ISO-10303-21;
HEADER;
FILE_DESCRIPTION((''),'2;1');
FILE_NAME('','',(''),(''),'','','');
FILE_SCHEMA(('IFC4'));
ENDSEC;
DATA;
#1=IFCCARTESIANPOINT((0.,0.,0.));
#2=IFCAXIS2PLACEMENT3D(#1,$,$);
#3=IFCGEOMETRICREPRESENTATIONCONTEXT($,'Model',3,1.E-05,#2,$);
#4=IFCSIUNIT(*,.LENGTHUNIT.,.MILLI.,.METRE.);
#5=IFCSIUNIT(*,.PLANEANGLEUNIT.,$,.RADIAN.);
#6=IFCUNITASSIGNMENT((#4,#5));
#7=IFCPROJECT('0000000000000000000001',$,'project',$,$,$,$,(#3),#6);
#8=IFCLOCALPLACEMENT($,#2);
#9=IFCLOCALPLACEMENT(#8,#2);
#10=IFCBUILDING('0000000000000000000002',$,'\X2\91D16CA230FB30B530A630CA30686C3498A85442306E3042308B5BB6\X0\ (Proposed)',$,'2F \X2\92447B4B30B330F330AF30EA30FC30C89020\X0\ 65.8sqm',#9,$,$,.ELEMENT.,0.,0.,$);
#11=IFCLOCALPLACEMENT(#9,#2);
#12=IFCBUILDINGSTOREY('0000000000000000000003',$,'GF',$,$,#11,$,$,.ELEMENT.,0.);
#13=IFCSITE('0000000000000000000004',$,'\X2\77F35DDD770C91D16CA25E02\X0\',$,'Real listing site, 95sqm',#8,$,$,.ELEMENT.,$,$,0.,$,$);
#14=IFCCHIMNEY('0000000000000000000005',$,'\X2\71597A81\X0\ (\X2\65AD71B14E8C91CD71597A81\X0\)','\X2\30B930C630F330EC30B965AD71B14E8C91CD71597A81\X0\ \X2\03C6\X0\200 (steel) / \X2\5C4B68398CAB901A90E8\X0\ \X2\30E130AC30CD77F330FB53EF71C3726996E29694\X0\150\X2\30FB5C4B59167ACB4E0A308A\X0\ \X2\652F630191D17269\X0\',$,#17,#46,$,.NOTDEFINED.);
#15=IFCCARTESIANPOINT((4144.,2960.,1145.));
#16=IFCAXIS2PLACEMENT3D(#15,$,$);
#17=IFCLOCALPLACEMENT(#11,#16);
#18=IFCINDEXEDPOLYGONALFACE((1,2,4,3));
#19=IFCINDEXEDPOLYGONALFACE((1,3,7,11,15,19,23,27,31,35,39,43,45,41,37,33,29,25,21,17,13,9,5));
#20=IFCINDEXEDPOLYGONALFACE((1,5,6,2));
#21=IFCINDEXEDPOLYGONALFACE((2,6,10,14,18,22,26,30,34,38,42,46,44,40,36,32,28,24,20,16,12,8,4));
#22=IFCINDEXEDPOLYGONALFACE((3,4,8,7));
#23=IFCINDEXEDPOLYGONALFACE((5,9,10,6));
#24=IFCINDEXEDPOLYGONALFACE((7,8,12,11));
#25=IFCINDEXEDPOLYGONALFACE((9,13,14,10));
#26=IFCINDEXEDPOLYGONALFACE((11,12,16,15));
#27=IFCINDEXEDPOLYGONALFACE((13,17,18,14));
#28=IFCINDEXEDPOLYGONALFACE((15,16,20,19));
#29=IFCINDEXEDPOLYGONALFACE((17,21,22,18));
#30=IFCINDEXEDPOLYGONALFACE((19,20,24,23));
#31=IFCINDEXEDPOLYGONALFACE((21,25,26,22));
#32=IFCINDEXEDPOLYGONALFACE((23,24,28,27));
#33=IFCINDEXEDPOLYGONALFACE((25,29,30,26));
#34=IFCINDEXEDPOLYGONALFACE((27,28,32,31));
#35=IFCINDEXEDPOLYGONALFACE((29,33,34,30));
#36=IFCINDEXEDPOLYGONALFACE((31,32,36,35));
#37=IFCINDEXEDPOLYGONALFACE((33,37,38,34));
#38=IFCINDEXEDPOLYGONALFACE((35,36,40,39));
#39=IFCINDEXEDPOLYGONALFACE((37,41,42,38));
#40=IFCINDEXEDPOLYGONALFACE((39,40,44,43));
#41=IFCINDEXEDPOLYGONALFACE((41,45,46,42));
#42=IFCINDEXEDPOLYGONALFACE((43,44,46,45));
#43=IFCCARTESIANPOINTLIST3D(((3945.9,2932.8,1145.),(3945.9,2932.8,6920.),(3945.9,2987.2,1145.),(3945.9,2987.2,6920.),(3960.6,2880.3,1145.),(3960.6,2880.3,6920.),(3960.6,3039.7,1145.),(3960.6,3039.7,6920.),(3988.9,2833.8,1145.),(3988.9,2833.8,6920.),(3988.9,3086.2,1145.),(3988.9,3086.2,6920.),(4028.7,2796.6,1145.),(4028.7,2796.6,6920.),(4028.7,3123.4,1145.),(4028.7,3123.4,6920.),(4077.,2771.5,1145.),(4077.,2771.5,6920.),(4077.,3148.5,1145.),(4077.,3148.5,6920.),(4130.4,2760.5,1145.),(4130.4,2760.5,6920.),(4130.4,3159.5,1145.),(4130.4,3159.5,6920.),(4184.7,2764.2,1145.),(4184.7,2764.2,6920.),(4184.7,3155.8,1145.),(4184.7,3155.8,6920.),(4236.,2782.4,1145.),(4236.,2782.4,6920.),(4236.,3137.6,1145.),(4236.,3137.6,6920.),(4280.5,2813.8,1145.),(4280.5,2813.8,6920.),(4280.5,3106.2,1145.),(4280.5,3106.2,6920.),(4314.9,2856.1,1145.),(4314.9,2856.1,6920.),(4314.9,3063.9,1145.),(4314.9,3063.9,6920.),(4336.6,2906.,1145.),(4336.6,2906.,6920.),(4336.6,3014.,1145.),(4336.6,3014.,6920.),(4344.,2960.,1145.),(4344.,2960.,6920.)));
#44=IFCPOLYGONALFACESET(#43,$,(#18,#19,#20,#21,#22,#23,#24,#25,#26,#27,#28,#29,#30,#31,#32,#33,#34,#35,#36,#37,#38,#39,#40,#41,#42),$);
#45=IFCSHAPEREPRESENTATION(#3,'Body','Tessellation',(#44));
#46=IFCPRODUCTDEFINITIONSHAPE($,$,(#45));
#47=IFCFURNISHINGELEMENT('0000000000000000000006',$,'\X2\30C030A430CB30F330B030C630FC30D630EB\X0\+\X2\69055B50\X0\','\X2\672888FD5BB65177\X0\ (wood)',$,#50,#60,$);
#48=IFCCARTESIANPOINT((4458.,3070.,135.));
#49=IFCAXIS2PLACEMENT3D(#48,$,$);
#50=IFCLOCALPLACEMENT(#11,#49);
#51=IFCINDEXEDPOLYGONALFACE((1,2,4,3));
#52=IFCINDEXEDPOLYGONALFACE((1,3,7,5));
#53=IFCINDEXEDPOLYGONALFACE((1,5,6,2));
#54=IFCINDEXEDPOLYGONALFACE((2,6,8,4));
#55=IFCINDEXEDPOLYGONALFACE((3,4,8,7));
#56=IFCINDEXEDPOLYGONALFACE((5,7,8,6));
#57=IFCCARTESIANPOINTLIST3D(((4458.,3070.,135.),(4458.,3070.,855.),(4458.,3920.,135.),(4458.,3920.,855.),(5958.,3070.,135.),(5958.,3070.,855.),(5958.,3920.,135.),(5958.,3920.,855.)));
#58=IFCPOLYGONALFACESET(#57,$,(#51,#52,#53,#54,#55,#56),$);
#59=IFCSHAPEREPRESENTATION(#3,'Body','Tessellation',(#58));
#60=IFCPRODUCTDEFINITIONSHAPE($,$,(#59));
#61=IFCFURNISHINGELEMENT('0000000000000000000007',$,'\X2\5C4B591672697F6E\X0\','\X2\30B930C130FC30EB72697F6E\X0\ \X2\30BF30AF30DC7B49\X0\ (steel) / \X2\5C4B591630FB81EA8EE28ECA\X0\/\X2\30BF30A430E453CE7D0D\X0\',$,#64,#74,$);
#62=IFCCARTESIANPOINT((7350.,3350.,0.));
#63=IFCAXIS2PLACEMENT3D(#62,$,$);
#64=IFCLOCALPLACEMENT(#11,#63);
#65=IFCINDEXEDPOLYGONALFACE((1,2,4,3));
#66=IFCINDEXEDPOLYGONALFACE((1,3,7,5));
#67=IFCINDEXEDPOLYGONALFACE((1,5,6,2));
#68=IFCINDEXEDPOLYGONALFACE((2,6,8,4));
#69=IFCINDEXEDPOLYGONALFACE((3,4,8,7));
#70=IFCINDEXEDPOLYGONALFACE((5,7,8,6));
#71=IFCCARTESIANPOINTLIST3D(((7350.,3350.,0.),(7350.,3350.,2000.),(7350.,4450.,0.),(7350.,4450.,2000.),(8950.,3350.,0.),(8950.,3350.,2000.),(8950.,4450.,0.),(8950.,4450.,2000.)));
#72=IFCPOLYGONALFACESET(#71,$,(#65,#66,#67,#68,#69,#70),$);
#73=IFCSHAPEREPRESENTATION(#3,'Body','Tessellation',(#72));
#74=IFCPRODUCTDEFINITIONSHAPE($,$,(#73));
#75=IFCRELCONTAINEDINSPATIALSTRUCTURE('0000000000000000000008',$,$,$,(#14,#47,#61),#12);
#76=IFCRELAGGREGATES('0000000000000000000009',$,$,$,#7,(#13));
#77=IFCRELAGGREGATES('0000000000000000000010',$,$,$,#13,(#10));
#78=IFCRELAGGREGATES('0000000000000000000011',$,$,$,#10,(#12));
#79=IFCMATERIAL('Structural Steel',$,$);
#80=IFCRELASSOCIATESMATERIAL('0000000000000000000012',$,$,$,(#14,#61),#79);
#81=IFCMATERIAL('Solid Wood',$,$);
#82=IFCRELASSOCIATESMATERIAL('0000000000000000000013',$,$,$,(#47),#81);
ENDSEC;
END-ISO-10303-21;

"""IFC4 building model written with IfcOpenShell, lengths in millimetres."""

from ifc_helpers import new_model, si_unit, frame, frame_2d, origin, origin_2d, place, context, project, spatial, rectangle, circle, extrude, material, element, save


model = new_model("IFC4")

# Units and contexts
model_context = context("Model", 3, precision=1e-05, world=origin())
ifc_project = project(units=[si_unit("LENGTHUNIT", "METRE", prefix="MILLI"), si_unit("PLANEANGLEUNIT", "RADIAN")], contexts=[model_context])

# Site, building, storey
site_placement = place(None, origin())
site = spatial("IfcSite", under=ifc_project, at=site_placement, Name="石川県金沢市", ObjectType="Real listing site, 95sqm", CompositionType="ELEMENT", RefElevation=0.0)
building_placement = place(site_placement, origin())
building = spatial("IfcBuilding", under=site, at=building_placement, Name="金沢・サウナと水風呂のある家 (Proposed)", ObjectType="2F 鉄筋コンクリート造 65.8sqm", CompositionType="ELEMENT", ElevationOfRefHeight=0.0, ElevationOfTerrain=0.0)
storey_placement = place(building_placement, origin())
storey = spatial("IfcBuildingStorey", under=building, at=storey_placement, Name="GF", CompositionType="ELEMENT", Elevation=0.0)

# Shared definitions
ifc_material_1 = material(Name="Solid Wood")

# Shared definitions
ifc_material_2 = material(Name="Structural Steel")

# Chimney
chimney_placement = place(storey_placement, frame((4144.0, 2960.0, 1145.0)))
element("IfcChimney", 1, at=chimney_placement, inside=storey, material=ifc_material_2, Name="煙突 (断熱二重煙突)", Description="ステンレス断熱二重煙突 φ200 (steel) / 屋根貫通部 メガネ石・可燃物離隔150・屋外立上り 支持金物", PredefinedType="NOTDEFINED", context=model_context, shape_type="SweptSolid", body=[
    extrude(circle(Radius=200.0, at=origin_2d()), frame((4144.0, 2960.0, 1145.0)), (0.0, 0.0, 1.0), 5775.0),
])

# Furnishing elements
furnishing_1_placement = place(storey_placement, frame((4458.0, 3070.0, 135.0)))
element("IfcFurnishingElement", 2, at=furnishing_1_placement, inside=storey, material=ifc_material_1, Name="ダイニングテーブル+椅子", Description="木製家具 (wood)", context=model_context, shape_type="SweptSolid", body=[
    extrude(rectangle(XDim=1500.0, YDim=850.0, at=frame_2d((750.0, 425.0))), frame((4458.0, 3070.0, 135.0)), (0.0, 0.0, 1.0), 720.0),
])
furnishing_2_placement = place(storey_placement, frame((7350.0, 3350.0, 0.0)))
element("IfcFurnishingElement", 3, at=furnishing_2_placement, inside=storey, material=ifc_material_2, Name="屋外物置", Description="スチール物置 タクボ等 (steel) / 屋外・自転車/タイヤ収納", context=model_context, shape_type="SweptSolid", body=[
    extrude(rectangle(XDim=1600.0, YDim=1100.0, at=frame_2d((800.0, 550.0))), frame((7350.0, 3350.0, 0.0)), (0.0, 0.0, 1.0), 2000.0),
])

save(model, "model.ifc")
